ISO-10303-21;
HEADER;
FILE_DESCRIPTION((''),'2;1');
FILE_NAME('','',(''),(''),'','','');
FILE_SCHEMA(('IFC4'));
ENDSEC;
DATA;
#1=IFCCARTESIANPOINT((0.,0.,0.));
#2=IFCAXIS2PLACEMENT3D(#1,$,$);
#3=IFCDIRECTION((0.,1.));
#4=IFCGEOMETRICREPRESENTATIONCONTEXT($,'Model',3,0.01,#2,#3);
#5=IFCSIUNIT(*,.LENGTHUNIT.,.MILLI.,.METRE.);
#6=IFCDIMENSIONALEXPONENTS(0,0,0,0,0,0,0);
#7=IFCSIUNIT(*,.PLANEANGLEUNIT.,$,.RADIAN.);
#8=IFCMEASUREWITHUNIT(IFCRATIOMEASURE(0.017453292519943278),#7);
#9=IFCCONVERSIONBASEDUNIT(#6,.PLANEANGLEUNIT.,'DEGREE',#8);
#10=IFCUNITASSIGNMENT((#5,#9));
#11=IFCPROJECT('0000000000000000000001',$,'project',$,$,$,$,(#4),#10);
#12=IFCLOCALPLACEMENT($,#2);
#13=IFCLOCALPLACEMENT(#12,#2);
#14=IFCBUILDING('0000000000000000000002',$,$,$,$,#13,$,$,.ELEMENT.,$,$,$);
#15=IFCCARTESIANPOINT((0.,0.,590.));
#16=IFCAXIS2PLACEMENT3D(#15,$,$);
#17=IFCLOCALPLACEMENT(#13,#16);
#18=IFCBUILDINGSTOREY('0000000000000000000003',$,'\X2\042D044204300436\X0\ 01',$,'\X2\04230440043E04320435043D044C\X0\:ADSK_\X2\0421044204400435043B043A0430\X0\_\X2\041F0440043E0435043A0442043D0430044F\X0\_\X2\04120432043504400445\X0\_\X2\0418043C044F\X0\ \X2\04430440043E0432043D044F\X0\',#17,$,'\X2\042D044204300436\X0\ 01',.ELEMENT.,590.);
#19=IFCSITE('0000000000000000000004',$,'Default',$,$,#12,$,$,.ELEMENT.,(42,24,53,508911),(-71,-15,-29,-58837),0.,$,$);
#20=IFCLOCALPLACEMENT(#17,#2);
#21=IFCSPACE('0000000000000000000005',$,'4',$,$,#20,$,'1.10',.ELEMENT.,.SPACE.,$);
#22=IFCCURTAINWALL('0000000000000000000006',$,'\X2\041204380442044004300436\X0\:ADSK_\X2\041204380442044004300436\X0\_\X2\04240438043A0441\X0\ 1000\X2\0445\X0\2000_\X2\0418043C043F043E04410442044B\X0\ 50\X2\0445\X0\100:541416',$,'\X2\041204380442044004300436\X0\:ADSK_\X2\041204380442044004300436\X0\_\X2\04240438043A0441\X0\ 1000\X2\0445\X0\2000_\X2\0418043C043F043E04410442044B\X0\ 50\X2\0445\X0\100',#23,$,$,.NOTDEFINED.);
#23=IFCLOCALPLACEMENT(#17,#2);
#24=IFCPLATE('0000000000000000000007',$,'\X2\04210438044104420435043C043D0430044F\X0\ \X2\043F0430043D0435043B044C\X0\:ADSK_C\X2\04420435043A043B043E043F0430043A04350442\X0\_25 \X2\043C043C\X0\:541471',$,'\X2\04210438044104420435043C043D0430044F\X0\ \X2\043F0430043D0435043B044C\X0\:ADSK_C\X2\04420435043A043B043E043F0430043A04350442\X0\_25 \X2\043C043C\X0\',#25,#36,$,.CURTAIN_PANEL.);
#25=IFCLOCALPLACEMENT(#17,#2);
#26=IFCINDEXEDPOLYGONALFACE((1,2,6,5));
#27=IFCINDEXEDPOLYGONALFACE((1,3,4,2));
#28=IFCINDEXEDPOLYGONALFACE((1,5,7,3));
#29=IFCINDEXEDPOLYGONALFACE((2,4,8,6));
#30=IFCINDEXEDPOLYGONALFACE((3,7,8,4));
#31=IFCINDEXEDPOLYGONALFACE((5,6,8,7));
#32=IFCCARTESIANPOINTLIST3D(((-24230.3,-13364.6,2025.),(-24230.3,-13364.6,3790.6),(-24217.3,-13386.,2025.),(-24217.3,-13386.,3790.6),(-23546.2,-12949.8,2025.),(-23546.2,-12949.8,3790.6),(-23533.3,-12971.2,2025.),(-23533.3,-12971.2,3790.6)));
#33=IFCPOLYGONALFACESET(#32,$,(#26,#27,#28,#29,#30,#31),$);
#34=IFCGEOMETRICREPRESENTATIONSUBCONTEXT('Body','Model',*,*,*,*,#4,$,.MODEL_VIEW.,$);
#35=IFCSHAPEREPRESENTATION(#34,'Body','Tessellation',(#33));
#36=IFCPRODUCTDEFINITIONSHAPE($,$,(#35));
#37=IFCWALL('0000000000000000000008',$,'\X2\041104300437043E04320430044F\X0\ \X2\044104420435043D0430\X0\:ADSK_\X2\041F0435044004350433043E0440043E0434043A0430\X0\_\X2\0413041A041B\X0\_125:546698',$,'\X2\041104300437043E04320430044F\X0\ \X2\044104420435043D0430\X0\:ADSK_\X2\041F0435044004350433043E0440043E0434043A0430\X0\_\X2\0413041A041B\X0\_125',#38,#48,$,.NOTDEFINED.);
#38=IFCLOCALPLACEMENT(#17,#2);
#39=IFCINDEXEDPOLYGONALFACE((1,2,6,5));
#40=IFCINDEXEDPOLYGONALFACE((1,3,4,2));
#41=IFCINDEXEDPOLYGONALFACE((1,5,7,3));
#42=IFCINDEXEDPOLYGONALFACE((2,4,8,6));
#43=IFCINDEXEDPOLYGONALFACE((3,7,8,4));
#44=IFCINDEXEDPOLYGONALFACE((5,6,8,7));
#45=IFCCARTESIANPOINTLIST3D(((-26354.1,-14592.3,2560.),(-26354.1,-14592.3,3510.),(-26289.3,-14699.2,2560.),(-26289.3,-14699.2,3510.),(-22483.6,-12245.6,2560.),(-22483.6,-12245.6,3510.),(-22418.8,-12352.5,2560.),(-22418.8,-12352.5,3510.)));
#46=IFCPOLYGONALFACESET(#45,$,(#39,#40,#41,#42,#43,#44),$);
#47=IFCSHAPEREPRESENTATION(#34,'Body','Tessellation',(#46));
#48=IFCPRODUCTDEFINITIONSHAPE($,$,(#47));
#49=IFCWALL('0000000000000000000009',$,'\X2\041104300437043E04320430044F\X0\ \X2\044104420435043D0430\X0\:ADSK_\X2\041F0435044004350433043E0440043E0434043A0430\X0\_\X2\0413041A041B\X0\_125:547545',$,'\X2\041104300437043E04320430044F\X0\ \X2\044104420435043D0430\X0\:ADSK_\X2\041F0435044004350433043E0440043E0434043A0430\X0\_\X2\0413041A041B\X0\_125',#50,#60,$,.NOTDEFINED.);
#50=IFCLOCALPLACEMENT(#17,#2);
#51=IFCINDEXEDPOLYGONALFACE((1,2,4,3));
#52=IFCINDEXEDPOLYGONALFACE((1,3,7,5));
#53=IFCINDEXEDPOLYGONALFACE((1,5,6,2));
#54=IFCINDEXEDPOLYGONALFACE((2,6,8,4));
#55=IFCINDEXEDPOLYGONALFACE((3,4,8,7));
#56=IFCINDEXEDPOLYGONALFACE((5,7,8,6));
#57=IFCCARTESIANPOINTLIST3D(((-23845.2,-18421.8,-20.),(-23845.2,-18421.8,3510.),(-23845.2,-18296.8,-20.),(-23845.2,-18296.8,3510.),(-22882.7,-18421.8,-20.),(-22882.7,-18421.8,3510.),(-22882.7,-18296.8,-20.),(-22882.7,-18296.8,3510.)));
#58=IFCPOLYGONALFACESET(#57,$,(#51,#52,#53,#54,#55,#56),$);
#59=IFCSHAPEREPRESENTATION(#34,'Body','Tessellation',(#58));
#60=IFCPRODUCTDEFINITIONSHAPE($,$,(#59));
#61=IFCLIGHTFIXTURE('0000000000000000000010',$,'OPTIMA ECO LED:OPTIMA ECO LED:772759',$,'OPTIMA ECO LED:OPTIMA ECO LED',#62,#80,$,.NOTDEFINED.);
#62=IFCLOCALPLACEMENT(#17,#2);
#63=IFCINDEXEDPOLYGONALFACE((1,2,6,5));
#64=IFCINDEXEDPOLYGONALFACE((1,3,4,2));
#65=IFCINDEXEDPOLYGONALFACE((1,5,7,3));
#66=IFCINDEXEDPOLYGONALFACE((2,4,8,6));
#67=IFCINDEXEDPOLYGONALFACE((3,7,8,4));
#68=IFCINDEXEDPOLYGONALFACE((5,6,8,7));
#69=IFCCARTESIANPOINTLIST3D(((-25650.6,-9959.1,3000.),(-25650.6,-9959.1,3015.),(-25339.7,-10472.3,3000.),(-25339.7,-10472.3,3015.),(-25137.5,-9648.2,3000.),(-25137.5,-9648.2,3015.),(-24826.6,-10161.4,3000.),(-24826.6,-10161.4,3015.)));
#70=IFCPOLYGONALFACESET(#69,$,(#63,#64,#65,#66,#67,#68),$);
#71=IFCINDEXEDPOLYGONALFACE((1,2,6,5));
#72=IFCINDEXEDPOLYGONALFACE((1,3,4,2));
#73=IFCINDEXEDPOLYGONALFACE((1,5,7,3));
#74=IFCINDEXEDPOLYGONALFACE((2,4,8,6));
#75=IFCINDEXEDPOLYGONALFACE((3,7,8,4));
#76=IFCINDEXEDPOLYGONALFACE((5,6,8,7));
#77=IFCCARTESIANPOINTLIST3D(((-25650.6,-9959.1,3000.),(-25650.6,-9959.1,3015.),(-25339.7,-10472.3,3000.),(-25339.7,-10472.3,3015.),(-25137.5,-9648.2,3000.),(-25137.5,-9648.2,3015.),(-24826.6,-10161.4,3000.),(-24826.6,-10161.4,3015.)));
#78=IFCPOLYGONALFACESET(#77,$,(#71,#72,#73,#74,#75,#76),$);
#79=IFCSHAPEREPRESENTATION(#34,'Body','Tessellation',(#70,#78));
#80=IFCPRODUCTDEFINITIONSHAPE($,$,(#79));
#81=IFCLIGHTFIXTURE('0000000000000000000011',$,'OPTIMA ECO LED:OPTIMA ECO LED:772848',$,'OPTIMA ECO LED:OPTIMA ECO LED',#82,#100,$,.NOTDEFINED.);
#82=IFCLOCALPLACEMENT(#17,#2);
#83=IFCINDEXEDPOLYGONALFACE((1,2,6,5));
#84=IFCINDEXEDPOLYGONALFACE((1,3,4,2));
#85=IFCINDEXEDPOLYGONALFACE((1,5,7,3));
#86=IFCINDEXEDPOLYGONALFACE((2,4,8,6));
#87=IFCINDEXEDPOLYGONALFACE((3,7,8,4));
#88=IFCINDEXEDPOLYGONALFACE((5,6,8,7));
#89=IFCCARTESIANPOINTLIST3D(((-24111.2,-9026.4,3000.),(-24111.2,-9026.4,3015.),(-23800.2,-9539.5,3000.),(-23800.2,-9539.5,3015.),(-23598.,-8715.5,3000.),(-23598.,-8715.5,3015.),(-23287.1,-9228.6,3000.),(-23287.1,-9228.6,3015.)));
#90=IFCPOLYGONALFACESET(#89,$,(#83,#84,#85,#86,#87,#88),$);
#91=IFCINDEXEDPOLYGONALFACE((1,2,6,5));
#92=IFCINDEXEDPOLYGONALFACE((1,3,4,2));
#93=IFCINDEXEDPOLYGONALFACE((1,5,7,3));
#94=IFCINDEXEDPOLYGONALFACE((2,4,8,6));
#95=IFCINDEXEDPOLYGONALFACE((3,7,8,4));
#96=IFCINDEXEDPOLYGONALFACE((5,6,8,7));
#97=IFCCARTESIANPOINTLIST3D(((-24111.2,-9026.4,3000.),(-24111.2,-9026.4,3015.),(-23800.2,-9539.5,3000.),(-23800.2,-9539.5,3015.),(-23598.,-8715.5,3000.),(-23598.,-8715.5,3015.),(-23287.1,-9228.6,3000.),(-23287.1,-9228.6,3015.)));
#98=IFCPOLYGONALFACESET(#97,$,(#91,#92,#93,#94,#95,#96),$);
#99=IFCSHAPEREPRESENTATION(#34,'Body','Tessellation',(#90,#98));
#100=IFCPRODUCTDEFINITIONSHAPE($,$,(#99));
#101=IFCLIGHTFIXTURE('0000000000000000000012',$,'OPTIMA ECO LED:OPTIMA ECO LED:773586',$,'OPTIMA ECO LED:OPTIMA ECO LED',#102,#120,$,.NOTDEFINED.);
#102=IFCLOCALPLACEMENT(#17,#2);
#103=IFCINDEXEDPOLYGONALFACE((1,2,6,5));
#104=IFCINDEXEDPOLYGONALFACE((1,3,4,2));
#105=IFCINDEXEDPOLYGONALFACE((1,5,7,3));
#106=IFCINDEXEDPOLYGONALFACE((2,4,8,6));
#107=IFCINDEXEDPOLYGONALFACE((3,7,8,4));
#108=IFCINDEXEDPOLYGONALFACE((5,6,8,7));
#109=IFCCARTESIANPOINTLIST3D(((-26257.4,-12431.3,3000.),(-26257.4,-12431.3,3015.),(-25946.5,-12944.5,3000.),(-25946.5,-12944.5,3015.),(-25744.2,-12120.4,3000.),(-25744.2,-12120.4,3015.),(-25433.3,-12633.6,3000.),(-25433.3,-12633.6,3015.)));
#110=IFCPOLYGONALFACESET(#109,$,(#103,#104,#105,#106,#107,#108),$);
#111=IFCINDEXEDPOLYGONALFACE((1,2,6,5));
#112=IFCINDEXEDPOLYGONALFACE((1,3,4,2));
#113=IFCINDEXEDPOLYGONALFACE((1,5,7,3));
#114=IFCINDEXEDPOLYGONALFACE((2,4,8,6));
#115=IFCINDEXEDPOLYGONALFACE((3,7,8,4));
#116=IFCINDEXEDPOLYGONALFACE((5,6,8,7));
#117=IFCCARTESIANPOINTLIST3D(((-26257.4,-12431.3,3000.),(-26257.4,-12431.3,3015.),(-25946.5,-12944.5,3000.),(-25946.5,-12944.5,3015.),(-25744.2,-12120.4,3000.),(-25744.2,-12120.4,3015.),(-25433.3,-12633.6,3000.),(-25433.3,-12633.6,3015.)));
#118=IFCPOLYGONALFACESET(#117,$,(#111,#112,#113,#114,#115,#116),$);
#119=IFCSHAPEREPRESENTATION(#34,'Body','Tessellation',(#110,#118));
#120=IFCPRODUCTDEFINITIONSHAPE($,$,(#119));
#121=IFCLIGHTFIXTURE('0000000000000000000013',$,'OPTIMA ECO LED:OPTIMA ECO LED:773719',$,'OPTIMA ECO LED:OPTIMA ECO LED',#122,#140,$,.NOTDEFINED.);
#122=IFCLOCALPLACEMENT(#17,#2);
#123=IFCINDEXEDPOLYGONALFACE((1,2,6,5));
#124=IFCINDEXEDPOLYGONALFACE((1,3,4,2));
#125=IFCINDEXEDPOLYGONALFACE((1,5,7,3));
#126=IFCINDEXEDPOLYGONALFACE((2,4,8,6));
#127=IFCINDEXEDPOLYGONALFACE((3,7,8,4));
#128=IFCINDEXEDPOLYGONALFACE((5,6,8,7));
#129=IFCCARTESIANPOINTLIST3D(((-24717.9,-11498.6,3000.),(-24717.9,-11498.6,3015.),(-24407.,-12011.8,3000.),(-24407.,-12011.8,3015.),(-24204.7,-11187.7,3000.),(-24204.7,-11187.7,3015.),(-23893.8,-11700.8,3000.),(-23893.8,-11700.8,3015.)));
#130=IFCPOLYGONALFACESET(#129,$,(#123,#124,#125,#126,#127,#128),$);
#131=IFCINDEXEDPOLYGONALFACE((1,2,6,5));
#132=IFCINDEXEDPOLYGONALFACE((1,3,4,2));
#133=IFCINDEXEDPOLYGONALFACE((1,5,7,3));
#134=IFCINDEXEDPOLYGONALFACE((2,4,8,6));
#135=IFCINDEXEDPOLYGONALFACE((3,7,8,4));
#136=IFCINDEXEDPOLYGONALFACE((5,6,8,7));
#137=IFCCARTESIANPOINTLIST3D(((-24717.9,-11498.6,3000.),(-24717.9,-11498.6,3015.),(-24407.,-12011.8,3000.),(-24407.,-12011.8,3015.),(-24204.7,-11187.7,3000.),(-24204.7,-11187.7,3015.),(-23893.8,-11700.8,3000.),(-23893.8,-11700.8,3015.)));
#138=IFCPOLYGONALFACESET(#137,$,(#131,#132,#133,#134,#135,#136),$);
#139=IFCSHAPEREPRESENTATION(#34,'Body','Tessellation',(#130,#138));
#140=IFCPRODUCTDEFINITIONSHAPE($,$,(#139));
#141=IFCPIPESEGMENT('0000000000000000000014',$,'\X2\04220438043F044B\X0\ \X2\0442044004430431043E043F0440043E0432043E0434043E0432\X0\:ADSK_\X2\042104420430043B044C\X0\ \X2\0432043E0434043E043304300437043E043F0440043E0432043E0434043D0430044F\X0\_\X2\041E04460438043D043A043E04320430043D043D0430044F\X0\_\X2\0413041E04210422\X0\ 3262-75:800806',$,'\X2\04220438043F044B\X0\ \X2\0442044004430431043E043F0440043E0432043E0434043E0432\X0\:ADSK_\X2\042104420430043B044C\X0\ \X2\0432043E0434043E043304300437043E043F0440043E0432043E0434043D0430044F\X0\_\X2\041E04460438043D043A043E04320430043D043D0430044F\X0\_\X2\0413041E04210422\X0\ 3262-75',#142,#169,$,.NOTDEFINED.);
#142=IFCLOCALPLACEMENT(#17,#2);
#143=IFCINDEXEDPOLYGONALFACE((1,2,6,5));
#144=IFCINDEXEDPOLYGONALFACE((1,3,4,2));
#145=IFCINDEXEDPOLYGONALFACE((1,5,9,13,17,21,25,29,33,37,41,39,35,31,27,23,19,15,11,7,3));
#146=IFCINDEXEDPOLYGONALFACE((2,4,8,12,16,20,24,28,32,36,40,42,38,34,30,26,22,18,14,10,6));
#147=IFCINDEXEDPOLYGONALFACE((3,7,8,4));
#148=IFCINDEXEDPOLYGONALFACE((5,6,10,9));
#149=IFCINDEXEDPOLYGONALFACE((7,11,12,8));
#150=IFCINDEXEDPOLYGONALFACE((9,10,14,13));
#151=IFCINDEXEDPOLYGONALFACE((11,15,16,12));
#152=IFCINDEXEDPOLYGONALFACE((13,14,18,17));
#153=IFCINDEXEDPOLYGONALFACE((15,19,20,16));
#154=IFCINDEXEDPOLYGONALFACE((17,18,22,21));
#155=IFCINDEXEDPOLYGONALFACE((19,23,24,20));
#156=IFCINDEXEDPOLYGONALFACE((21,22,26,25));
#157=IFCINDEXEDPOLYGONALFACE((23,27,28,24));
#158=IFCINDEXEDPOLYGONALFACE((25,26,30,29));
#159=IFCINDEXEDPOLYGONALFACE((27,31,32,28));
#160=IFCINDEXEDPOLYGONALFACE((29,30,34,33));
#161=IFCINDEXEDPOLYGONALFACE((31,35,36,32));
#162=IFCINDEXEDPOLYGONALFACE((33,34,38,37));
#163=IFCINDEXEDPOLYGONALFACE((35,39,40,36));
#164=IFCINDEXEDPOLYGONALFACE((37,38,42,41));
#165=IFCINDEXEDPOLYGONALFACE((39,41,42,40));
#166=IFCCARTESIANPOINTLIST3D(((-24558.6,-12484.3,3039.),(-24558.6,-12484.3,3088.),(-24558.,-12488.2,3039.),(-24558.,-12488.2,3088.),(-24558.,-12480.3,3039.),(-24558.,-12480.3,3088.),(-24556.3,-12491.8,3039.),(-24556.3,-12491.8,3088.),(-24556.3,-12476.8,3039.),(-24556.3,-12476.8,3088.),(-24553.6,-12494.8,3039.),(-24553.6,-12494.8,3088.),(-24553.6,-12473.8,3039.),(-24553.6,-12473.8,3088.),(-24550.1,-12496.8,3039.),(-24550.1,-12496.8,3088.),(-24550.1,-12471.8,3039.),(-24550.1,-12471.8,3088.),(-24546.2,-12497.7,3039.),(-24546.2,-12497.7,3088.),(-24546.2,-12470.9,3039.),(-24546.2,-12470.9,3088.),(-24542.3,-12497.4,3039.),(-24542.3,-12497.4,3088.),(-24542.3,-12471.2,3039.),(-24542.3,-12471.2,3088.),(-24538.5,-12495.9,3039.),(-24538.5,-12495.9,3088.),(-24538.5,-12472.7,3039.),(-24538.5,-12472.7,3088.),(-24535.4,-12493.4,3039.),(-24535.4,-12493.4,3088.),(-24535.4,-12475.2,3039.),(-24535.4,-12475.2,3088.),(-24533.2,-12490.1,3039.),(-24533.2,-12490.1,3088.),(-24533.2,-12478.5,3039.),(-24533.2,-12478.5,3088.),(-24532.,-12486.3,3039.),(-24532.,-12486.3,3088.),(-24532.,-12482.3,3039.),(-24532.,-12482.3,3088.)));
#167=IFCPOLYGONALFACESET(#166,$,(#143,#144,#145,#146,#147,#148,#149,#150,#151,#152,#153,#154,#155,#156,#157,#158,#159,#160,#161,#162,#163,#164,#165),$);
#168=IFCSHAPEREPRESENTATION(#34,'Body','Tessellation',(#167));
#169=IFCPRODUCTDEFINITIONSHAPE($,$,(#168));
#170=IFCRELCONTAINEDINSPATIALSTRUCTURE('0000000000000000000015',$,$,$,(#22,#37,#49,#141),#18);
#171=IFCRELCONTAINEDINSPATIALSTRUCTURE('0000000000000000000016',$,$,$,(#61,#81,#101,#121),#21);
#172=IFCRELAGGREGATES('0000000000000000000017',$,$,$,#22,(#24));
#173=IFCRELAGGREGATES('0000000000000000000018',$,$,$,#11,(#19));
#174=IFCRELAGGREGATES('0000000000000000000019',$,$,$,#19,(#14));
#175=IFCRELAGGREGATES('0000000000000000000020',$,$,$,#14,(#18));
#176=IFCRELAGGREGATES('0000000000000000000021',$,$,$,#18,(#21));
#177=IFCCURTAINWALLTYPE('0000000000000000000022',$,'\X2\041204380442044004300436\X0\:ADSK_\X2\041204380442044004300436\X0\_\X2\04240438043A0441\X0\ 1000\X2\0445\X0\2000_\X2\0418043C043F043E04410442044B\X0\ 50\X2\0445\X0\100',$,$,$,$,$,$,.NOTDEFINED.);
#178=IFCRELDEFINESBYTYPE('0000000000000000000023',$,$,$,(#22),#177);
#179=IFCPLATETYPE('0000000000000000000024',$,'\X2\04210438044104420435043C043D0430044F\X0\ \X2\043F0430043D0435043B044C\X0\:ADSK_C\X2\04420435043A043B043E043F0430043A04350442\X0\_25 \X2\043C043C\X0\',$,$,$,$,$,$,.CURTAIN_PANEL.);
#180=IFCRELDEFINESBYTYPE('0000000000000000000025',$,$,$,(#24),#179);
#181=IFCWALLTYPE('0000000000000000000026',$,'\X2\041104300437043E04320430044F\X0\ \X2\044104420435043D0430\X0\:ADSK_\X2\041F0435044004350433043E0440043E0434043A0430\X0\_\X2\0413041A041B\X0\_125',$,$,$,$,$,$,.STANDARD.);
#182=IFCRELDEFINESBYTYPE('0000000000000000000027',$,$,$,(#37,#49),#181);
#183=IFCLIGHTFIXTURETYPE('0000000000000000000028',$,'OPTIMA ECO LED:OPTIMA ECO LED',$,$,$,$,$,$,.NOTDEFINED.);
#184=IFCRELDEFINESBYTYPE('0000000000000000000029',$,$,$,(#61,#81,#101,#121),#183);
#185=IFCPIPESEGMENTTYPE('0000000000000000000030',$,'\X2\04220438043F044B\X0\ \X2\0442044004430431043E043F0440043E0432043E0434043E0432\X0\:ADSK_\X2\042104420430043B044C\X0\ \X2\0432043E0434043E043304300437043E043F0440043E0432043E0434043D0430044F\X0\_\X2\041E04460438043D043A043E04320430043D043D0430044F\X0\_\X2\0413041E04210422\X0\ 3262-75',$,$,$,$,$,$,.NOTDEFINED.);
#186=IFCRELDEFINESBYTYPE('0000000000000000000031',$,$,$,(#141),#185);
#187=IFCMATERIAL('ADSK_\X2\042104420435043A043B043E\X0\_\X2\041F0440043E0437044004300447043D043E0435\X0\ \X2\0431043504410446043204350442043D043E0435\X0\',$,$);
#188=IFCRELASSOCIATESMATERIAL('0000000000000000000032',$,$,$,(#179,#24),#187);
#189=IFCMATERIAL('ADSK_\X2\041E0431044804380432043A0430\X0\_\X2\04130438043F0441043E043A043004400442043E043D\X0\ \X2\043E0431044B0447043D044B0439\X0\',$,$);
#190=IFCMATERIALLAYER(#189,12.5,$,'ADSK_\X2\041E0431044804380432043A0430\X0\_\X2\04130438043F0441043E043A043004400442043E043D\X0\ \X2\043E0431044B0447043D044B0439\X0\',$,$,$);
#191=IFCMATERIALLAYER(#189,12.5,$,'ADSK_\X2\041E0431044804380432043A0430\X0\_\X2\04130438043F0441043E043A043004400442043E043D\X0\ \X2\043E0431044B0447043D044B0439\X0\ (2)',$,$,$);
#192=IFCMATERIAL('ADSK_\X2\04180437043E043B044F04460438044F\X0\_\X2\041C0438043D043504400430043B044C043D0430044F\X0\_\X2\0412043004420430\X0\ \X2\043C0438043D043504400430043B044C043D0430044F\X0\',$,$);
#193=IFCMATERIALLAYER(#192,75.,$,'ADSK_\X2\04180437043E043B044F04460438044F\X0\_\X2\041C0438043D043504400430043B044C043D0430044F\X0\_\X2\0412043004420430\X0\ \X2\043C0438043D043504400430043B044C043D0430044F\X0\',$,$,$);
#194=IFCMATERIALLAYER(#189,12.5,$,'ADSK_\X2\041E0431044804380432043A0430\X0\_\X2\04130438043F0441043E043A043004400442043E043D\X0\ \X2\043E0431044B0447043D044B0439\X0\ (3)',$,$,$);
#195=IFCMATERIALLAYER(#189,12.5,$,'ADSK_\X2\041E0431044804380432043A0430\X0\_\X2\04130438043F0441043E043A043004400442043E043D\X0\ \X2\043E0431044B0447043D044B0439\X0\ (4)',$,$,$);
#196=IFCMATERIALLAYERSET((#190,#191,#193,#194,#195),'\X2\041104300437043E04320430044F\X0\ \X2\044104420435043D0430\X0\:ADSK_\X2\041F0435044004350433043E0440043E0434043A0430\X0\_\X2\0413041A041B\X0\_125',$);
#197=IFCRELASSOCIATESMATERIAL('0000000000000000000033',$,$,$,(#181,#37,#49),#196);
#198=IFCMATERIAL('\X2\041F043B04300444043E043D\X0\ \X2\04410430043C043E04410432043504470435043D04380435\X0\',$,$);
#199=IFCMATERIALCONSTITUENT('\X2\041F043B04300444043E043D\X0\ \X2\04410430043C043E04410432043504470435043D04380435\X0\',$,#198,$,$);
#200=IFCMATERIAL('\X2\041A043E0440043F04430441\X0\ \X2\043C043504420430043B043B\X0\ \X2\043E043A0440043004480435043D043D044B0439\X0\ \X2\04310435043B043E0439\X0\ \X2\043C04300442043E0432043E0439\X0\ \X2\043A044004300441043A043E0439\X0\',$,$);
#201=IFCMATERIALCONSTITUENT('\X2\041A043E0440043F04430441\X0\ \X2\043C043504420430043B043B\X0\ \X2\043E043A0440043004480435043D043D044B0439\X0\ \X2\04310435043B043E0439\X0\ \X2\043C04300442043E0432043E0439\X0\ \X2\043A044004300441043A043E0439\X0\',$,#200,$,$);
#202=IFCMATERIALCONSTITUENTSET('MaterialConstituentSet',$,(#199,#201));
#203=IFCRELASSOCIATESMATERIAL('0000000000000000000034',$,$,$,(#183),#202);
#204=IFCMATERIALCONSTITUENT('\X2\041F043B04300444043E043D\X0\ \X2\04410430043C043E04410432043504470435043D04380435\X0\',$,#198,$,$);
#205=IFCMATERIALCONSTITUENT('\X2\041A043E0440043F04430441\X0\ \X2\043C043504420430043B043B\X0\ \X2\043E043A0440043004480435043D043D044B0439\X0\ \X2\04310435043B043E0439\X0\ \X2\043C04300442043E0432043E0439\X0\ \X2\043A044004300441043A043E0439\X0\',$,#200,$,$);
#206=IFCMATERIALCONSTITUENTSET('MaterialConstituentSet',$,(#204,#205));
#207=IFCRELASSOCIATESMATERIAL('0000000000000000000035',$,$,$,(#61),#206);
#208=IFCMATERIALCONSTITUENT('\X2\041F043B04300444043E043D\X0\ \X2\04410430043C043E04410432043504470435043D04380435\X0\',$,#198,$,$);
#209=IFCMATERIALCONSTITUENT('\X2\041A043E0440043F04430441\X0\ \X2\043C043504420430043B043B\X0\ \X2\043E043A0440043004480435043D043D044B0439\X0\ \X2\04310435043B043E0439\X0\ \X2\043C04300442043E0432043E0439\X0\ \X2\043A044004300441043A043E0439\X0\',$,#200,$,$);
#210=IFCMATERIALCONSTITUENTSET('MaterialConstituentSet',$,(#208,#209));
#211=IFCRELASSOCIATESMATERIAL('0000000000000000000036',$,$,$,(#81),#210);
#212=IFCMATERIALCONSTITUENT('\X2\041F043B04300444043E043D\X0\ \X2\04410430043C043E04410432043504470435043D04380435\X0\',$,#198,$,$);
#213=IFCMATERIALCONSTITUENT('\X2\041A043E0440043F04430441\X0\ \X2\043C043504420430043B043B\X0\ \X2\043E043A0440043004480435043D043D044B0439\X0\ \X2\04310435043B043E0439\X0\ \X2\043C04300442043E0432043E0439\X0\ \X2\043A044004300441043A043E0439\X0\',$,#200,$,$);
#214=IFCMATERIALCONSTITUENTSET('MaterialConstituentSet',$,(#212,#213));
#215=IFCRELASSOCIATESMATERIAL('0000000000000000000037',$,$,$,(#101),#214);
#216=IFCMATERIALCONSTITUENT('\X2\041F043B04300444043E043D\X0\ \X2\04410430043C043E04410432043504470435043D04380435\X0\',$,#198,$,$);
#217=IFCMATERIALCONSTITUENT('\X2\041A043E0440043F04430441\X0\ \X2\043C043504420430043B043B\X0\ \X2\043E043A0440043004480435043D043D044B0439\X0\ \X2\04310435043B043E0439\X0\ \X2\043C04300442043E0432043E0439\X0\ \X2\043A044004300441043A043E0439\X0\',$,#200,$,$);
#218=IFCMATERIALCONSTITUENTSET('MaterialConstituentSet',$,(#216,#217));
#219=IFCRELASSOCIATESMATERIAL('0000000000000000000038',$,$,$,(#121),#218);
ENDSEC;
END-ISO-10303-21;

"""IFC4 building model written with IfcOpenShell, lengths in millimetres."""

from ifc_helpers import new_model, entity, si_unit, converted_unit, direction, frame, frame_2d, origin, origin_2d_with_axis, place, context, subcontext, project, spatial, rectangle, circle, extrude, source, transform, mapped, material, layer, layer_set, layer_usage, constituent, constituent_set, type_object, type_shapes, element, aggregate, save


model = new_model("IFC4")

# Units and contexts
model_context = context("Model", 3, precision=0.01, world=origin(), true_north=direction((0.0, 1.0)))
body_context = subcontext(model_context, "Body", "Model", "MODEL_VIEW")
ifc_project = project(units=[si_unit("LENGTHUNIT", "METRE", prefix="MILLI"), converted_unit("PLANEANGLEUNIT", "DEGREE", entity("IfcRatioMeasure", 0.017453292519943278), si_unit("PLANEANGLEUNIT", "RADIAN"), dimensions=[0, 0, 0, 0, 0, 0, 0])], contexts=[model_context])

# Site, building, storey
site_placement = place(None, origin())
site = spatial("IfcSite", under=ifc_project, at=site_placement, Name="Default", CompositionType="ELEMENT", RefLatitude=(42, 24, 53, 508911), RefLongitude=(-71, -15, -29, -58837), RefElevation=0.0)
building_placement = place(site_placement, origin())
building = spatial("IfcBuilding", under=site, at=building_placement, CompositionType="ELEMENT")
storey_placement = place(building_placement, frame((0.0, 0.0, 590.0)))
storey = spatial("IfcBuildingStorey", under=building, at=storey_placement, Name="Этаж 01", ObjectType="Уровень:ADSK_Стрелка_Проектная_Вверх_Имя уровня", LongName="Этаж 01", CompositionType="ELEMENT", Elevation=590.0)

# Curtain wall
curtain_wall_type = type_object("IfcCurtainWallType", Name="Витраж:ADSK_Витраж_Фикс 1000х2000_Импосты 50х100", PredefinedType="NOTDEFINED")
curtain_wall_placement = place(storey_placement, frame((0.0, 0.0, -590.0)))
curtain_wall = element("IfcCurtainWall", 1, at=curtain_wall_placement, inside=storey, type_object=curtain_wall_type, Name="Витраж:ADSK_Витраж_Фикс 1000х2000_Импосты 50х100:541416", ObjectType="Витраж:ADSK_Витраж_Фикс 1000х2000_Импосты 50х100", PredefinedType="NOTDEFINED")

# Plate
ifc_material_1 = material(Name="ADSK_Стекло_Прозрачное бесцветное")
plate_type_1 = type_object("IfcPlateType", Name="Системная панель:ADSK_Cтеклопакет_25 мм", PredefinedType="CURTAIN_PANEL", material=ifc_material_1)
shared_shape_1 = source(origin(), body_context, "Body", "SweptSolid", [
    extrude(rectangle(XDim=25.0, YDim=800.0, at=frame_2d((0.0, 0.0), x_axis=(1.0, 0.0))), frame((0.0, 0.0, 0.0), z_axis=(0.0, 0.0, 1.0), x_axis=(0.0, 1.0, 0.0)), (0.0, 0.0, 1.0), 1765.6),
])
type_shapes(plate_type_1, [shared_shape_1])
plate_1_placement = place(curtain_wall_placement, frame((-23881.8, -13167.9, 2615.0), z_axis=(0.0, 0.0, 1.0), x_axis=(0.855102, 0.51846, 0.0)))
plate_1 = element("IfcPlate", 2, at=plate_1_placement, type_object=plate_type_1, material=ifc_material_1, Name="Системная панель:ADSK_Cтеклопакет_25 мм:541471", ObjectType="Системная панель:ADSK_Cтеклопакет_25 мм", PredefinedType="CURTAIN_PANEL", context=body_context, shape_type="MappedRepresentation", body=[
    mapped(shared_shape_1, transform((0.0, 0.0, 0.0), scale=1.0)),
])
aggregate(curtain_wall, [plate_1])

# Walls
ifc_material_2 = material(Name="ADSK_Обшивка_Гипсокартон обычный")
ifc_layer_1 = layer(ifc_material_2, 12.5, Name="ADSK_Обшивка_Гипсокартон обычный")
ifc_layer_2 = layer(ifc_material_2, 12.5, Name="ADSK_Обшивка_Гипсокартон обычный (2)")
ifc_material_3 = material(Name="ADSK_Изоляция_Минеральная_Вата минеральная")
ifc_layer_3 = layer(ifc_material_3, 75.0, Name="ADSK_Изоляция_Минеральная_Вата минеральная")
ifc_layer_4 = layer(ifc_material_2, 12.5, Name="ADSK_Обшивка_Гипсокартон обычный (3)")
ifc_layer_5 = layer(ifc_material_2, 12.5, Name="ADSK_Обшивка_Гипсокартон обычный (4)")
ifc_layer_set = layer_set([ifc_layer_1, ifc_layer_2, ifc_layer_3, ifc_layer_4, ifc_layer_5], Name="Базовая стена:ADSK_Перегородка_ГКЛ_125")
ifc_layer_usage_1 = layer_usage(ifc_layer_set, "AXIS2", "NEGATIVE", 62.5)
wall_type = type_object("IfcWallType", Name="Базовая стена:ADSK_Перегородка_ГКЛ_125", PredefinedType="STANDARD", material=ifc_layer_set)
wall_1_placement = place(storey_placement, frame((-26321.7, -14645.8, 2560.0), z_axis=(0.0, 0.0, 1.0), x_axis=(0.855102, 0.51846, 0.0)))
element("IfcWall", 3, at=wall_1_placement, inside=storey, type_object=wall_type, material=ifc_layer_usage_1, Name="Базовая стена:ADSK_Перегородка_ГКЛ_125:546698", ObjectType="Базовая стена:ADSK_Перегородка_ГКЛ_125", PredefinedType="NOTDEFINED", context=body_context, shape_type="SweptSolid", body=[
    extrude(rectangle(XDim=4526.3, YDim=125.0, at=frame_2d((2263.2, 0.0), x_axis=(-1.0, 0.0))), origin(), (0.0, 0.0, 1.0), 950.0),
])
ifc_layer_usage_2 = layer_usage(ifc_layer_set, "AXIS2", "NEGATIVE", 62.5)
wall_2_placement = place(storey_placement, frame((-23845.2, -18359.3, -20.0)))
element("IfcWall", 4, at=wall_2_placement, inside=storey, type_object=wall_type, material=ifc_layer_usage_2, Name="Базовая стена:ADSK_Перегородка_ГКЛ_125:547545", ObjectType="Базовая стена:ADSK_Перегородка_ГКЛ_125", PredefinedType="NOTDEFINED", context=body_context, shape_type="SweptSolid", body=[
    extrude(rectangle(XDim=962.5, YDim=125.0, at=frame_2d((481.3, 0.0), x_axis=(-1.0, 0.0))), origin(), (0.0, 0.0, 1.0), 3530.0),
])

# Shared definitions
space_placement = place(storey_placement, origin())
space = spatial("IfcSpace", under=storey, at=space_placement, Name="4", LongName="1.10", CompositionType="ELEMENT", PredefinedType="SPACE")

# Light fixtures
ifc_material_4 = material(Name="Плафон самосвечение")
ifc_constituent_1 = constituent(ifc_material_4, Name="Плафон самосвечение")
ifc_material_5 = material(Name="Корпус металл окрашенный белой матовой краской")
ifc_constituent_2 = constituent(ifc_material_5, Name="Корпус металл окрашенный белой матовой краской")
ifc_constituent_set_1 = constituent_set(constituents=[ifc_constituent_1, ifc_constituent_2], Name="MaterialConstituentSet")
ifc_constituent_3 = constituent(ifc_material_4, Name="Плафон самосвечение")
ifc_constituent_4 = constituent(ifc_material_5, Name="Корпус металл окрашенный белой матовой краской")
ifc_constituent_set_2 = constituent_set(constituents=[ifc_constituent_3, ifc_constituent_4], Name="MaterialConstituentSet")
light_fixture_type = type_object("IfcLightFixtureType", Name="OPTIMA ECO LED:OPTIMA ECO LED", PredefinedType="NOTDEFINED", material=ifc_constituent_set_2)
shared_shape_2 = source(origin(), body_context, "Body", "SweptSolid", [
    extrude(rectangle(XDim=600.0, YDim=600.0, at=frame_2d((0.0, 0.0), x_axis=(1.0, 0.0))), frame((0.0, 0.0, -15.0)), (0.0, 0.0, 1.0), 15.0),
    extrude(rectangle(XDim=600.0, YDim=600.0, at=frame_2d((0.0, 0.0), x_axis=(1.0, 0.0))), frame((0.0, 0.0, -15.0)), (0.0, 0.0, 1.0), 15.0),
])
type_shapes(light_fixture_type, [shared_shape_2])
light_fixture_1_placement = place(space_placement, frame((-25238.6, -10060.2, 3000.0), z_axis=(0.0, 0.0, -1.0), x_axis=(0.855267, 0.518188, 0.0)))
element("IfcLightFixture", 5, at=light_fixture_1_placement, inside=space, type_object=light_fixture_type, material=ifc_constituent_set_1, Name="OPTIMA ECO LED:OPTIMA ECO LED:772759", ObjectType="OPTIMA ECO LED:OPTIMA ECO LED", PredefinedType="NOTDEFINED", context=body_context, shape_type="MappedRepresentation", body=[
    mapped(shared_shape_2, transform((0.0, 0.0, 0.0), scale=1.0)),
])
ifc_constituent_5 = constituent(ifc_material_4, Name="Плафон самосвечение")
ifc_constituent_6 = constituent(ifc_material_5, Name="Корпус металл окрашенный белой матовой краской")
ifc_constituent_set_3 = constituent_set(constituents=[ifc_constituent_5, ifc_constituent_6], Name="MaterialConstituentSet")
light_fixture_2_placement = place(space_placement, frame((-23699.1, -9127.5, 3000.0), z_axis=(0.0, 0.0, -1.0), x_axis=(0.855267, 0.518188, 0.0)))
element("IfcLightFixture", 6, at=light_fixture_2_placement, inside=space, type_object=light_fixture_type, material=ifc_constituent_set_3, Name="OPTIMA ECO LED:OPTIMA ECO LED:772848", ObjectType="OPTIMA ECO LED:OPTIMA ECO LED", PredefinedType="NOTDEFINED", context=body_context, shape_type="MappedRepresentation", body=[
    mapped(shared_shape_2, transform((0.0, 0.0, 0.0), scale=1.0)),
])
ifc_constituent_7 = constituent(ifc_material_4, Name="Плафон самосвечение")
ifc_constituent_8 = constituent(ifc_material_5, Name="Корпус металл окрашенный белой матовой краской")
ifc_constituent_set_4 = constituent_set(constituents=[ifc_constituent_7, ifc_constituent_8], Name="MaterialConstituentSet")
light_fixture_3_placement = place(space_placement, frame((-25845.3, -12532.5, 3000.0), z_axis=(0.0, 0.0, -1.0), x_axis=(0.855267, 0.518188, 0.0)))
element("IfcLightFixture", 7, at=light_fixture_3_placement, inside=space, type_object=light_fixture_type, material=ifc_constituent_set_4, Name="OPTIMA ECO LED:OPTIMA ECO LED:773586", ObjectType="OPTIMA ECO LED:OPTIMA ECO LED", PredefinedType="NOTDEFINED", context=body_context, shape_type="MappedRepresentation", body=[
    mapped(shared_shape_2, transform((0.0, 0.0, 0.0), scale=1.0)),
])
ifc_constituent_9 = constituent(ifc_material_4, Name="Плафон самосвечение")
ifc_constituent_10 = constituent(ifc_material_5, Name="Корпус металл окрашенный белой матовой краской")
ifc_constituent_set_5 = constituent_set(constituents=[ifc_constituent_9, ifc_constituent_10], Name="MaterialConstituentSet")
light_fixture_4_placement = place(space_placement, frame((-24305.9, -11599.7, 3000.0), z_axis=(0.0, 0.0, -1.0), x_axis=(0.855267, 0.518188, 0.0)))
element("IfcLightFixture", 8, at=light_fixture_4_placement, inside=space, type_object=light_fixture_type, material=ifc_constituent_set_5, Name="OPTIMA ECO LED:OPTIMA ECO LED:773719", ObjectType="OPTIMA ECO LED:OPTIMA ECO LED", PredefinedType="NOTDEFINED", context=body_context, shape_type="MappedRepresentation", body=[
    mapped(shared_shape_2, transform((0.0, 0.0, 0.0), scale=1.0)),
])

# Pipe segment
pipe_segment_type = type_object("IfcPipeSegmentType", Name="Типы трубопроводов:ADSK_Сталь водогазопроводная_Оцинкованная_ГОСТ 3262-75", PredefinedType="NOTDEFINED")
pipe_segment_1_placement = place(storey_placement, frame((-24560.2, -12499.3, 3088.0)))
element("IfcPipeSegment", 9, at=pipe_segment_1_placement, inside=storey, type_object=pipe_segment_type, Name="Типы трубопроводов:ADSK_Сталь водогазопроводная_Оцинкованная_ГОСТ 3262-75:800806", ObjectType="Типы трубопроводов:ADSK_Сталь водогазопроводная_Оцинкованная_ГОСТ 3262-75", PredefinedType="NOTDEFINED", context=body_context, shape_type="SweptSolid", body=[
    extrude(circle(Radius=13.4, at=origin_2d_with_axis()), frame((15.0, 15.0, -49.0), z_axis=(0.0, 0.0, 1.0), x_axis=(-1.0, 0.0, 0.0)), (0.0, 0.0, 1.0), 49.0),
])

save(model, "model.ifc")
